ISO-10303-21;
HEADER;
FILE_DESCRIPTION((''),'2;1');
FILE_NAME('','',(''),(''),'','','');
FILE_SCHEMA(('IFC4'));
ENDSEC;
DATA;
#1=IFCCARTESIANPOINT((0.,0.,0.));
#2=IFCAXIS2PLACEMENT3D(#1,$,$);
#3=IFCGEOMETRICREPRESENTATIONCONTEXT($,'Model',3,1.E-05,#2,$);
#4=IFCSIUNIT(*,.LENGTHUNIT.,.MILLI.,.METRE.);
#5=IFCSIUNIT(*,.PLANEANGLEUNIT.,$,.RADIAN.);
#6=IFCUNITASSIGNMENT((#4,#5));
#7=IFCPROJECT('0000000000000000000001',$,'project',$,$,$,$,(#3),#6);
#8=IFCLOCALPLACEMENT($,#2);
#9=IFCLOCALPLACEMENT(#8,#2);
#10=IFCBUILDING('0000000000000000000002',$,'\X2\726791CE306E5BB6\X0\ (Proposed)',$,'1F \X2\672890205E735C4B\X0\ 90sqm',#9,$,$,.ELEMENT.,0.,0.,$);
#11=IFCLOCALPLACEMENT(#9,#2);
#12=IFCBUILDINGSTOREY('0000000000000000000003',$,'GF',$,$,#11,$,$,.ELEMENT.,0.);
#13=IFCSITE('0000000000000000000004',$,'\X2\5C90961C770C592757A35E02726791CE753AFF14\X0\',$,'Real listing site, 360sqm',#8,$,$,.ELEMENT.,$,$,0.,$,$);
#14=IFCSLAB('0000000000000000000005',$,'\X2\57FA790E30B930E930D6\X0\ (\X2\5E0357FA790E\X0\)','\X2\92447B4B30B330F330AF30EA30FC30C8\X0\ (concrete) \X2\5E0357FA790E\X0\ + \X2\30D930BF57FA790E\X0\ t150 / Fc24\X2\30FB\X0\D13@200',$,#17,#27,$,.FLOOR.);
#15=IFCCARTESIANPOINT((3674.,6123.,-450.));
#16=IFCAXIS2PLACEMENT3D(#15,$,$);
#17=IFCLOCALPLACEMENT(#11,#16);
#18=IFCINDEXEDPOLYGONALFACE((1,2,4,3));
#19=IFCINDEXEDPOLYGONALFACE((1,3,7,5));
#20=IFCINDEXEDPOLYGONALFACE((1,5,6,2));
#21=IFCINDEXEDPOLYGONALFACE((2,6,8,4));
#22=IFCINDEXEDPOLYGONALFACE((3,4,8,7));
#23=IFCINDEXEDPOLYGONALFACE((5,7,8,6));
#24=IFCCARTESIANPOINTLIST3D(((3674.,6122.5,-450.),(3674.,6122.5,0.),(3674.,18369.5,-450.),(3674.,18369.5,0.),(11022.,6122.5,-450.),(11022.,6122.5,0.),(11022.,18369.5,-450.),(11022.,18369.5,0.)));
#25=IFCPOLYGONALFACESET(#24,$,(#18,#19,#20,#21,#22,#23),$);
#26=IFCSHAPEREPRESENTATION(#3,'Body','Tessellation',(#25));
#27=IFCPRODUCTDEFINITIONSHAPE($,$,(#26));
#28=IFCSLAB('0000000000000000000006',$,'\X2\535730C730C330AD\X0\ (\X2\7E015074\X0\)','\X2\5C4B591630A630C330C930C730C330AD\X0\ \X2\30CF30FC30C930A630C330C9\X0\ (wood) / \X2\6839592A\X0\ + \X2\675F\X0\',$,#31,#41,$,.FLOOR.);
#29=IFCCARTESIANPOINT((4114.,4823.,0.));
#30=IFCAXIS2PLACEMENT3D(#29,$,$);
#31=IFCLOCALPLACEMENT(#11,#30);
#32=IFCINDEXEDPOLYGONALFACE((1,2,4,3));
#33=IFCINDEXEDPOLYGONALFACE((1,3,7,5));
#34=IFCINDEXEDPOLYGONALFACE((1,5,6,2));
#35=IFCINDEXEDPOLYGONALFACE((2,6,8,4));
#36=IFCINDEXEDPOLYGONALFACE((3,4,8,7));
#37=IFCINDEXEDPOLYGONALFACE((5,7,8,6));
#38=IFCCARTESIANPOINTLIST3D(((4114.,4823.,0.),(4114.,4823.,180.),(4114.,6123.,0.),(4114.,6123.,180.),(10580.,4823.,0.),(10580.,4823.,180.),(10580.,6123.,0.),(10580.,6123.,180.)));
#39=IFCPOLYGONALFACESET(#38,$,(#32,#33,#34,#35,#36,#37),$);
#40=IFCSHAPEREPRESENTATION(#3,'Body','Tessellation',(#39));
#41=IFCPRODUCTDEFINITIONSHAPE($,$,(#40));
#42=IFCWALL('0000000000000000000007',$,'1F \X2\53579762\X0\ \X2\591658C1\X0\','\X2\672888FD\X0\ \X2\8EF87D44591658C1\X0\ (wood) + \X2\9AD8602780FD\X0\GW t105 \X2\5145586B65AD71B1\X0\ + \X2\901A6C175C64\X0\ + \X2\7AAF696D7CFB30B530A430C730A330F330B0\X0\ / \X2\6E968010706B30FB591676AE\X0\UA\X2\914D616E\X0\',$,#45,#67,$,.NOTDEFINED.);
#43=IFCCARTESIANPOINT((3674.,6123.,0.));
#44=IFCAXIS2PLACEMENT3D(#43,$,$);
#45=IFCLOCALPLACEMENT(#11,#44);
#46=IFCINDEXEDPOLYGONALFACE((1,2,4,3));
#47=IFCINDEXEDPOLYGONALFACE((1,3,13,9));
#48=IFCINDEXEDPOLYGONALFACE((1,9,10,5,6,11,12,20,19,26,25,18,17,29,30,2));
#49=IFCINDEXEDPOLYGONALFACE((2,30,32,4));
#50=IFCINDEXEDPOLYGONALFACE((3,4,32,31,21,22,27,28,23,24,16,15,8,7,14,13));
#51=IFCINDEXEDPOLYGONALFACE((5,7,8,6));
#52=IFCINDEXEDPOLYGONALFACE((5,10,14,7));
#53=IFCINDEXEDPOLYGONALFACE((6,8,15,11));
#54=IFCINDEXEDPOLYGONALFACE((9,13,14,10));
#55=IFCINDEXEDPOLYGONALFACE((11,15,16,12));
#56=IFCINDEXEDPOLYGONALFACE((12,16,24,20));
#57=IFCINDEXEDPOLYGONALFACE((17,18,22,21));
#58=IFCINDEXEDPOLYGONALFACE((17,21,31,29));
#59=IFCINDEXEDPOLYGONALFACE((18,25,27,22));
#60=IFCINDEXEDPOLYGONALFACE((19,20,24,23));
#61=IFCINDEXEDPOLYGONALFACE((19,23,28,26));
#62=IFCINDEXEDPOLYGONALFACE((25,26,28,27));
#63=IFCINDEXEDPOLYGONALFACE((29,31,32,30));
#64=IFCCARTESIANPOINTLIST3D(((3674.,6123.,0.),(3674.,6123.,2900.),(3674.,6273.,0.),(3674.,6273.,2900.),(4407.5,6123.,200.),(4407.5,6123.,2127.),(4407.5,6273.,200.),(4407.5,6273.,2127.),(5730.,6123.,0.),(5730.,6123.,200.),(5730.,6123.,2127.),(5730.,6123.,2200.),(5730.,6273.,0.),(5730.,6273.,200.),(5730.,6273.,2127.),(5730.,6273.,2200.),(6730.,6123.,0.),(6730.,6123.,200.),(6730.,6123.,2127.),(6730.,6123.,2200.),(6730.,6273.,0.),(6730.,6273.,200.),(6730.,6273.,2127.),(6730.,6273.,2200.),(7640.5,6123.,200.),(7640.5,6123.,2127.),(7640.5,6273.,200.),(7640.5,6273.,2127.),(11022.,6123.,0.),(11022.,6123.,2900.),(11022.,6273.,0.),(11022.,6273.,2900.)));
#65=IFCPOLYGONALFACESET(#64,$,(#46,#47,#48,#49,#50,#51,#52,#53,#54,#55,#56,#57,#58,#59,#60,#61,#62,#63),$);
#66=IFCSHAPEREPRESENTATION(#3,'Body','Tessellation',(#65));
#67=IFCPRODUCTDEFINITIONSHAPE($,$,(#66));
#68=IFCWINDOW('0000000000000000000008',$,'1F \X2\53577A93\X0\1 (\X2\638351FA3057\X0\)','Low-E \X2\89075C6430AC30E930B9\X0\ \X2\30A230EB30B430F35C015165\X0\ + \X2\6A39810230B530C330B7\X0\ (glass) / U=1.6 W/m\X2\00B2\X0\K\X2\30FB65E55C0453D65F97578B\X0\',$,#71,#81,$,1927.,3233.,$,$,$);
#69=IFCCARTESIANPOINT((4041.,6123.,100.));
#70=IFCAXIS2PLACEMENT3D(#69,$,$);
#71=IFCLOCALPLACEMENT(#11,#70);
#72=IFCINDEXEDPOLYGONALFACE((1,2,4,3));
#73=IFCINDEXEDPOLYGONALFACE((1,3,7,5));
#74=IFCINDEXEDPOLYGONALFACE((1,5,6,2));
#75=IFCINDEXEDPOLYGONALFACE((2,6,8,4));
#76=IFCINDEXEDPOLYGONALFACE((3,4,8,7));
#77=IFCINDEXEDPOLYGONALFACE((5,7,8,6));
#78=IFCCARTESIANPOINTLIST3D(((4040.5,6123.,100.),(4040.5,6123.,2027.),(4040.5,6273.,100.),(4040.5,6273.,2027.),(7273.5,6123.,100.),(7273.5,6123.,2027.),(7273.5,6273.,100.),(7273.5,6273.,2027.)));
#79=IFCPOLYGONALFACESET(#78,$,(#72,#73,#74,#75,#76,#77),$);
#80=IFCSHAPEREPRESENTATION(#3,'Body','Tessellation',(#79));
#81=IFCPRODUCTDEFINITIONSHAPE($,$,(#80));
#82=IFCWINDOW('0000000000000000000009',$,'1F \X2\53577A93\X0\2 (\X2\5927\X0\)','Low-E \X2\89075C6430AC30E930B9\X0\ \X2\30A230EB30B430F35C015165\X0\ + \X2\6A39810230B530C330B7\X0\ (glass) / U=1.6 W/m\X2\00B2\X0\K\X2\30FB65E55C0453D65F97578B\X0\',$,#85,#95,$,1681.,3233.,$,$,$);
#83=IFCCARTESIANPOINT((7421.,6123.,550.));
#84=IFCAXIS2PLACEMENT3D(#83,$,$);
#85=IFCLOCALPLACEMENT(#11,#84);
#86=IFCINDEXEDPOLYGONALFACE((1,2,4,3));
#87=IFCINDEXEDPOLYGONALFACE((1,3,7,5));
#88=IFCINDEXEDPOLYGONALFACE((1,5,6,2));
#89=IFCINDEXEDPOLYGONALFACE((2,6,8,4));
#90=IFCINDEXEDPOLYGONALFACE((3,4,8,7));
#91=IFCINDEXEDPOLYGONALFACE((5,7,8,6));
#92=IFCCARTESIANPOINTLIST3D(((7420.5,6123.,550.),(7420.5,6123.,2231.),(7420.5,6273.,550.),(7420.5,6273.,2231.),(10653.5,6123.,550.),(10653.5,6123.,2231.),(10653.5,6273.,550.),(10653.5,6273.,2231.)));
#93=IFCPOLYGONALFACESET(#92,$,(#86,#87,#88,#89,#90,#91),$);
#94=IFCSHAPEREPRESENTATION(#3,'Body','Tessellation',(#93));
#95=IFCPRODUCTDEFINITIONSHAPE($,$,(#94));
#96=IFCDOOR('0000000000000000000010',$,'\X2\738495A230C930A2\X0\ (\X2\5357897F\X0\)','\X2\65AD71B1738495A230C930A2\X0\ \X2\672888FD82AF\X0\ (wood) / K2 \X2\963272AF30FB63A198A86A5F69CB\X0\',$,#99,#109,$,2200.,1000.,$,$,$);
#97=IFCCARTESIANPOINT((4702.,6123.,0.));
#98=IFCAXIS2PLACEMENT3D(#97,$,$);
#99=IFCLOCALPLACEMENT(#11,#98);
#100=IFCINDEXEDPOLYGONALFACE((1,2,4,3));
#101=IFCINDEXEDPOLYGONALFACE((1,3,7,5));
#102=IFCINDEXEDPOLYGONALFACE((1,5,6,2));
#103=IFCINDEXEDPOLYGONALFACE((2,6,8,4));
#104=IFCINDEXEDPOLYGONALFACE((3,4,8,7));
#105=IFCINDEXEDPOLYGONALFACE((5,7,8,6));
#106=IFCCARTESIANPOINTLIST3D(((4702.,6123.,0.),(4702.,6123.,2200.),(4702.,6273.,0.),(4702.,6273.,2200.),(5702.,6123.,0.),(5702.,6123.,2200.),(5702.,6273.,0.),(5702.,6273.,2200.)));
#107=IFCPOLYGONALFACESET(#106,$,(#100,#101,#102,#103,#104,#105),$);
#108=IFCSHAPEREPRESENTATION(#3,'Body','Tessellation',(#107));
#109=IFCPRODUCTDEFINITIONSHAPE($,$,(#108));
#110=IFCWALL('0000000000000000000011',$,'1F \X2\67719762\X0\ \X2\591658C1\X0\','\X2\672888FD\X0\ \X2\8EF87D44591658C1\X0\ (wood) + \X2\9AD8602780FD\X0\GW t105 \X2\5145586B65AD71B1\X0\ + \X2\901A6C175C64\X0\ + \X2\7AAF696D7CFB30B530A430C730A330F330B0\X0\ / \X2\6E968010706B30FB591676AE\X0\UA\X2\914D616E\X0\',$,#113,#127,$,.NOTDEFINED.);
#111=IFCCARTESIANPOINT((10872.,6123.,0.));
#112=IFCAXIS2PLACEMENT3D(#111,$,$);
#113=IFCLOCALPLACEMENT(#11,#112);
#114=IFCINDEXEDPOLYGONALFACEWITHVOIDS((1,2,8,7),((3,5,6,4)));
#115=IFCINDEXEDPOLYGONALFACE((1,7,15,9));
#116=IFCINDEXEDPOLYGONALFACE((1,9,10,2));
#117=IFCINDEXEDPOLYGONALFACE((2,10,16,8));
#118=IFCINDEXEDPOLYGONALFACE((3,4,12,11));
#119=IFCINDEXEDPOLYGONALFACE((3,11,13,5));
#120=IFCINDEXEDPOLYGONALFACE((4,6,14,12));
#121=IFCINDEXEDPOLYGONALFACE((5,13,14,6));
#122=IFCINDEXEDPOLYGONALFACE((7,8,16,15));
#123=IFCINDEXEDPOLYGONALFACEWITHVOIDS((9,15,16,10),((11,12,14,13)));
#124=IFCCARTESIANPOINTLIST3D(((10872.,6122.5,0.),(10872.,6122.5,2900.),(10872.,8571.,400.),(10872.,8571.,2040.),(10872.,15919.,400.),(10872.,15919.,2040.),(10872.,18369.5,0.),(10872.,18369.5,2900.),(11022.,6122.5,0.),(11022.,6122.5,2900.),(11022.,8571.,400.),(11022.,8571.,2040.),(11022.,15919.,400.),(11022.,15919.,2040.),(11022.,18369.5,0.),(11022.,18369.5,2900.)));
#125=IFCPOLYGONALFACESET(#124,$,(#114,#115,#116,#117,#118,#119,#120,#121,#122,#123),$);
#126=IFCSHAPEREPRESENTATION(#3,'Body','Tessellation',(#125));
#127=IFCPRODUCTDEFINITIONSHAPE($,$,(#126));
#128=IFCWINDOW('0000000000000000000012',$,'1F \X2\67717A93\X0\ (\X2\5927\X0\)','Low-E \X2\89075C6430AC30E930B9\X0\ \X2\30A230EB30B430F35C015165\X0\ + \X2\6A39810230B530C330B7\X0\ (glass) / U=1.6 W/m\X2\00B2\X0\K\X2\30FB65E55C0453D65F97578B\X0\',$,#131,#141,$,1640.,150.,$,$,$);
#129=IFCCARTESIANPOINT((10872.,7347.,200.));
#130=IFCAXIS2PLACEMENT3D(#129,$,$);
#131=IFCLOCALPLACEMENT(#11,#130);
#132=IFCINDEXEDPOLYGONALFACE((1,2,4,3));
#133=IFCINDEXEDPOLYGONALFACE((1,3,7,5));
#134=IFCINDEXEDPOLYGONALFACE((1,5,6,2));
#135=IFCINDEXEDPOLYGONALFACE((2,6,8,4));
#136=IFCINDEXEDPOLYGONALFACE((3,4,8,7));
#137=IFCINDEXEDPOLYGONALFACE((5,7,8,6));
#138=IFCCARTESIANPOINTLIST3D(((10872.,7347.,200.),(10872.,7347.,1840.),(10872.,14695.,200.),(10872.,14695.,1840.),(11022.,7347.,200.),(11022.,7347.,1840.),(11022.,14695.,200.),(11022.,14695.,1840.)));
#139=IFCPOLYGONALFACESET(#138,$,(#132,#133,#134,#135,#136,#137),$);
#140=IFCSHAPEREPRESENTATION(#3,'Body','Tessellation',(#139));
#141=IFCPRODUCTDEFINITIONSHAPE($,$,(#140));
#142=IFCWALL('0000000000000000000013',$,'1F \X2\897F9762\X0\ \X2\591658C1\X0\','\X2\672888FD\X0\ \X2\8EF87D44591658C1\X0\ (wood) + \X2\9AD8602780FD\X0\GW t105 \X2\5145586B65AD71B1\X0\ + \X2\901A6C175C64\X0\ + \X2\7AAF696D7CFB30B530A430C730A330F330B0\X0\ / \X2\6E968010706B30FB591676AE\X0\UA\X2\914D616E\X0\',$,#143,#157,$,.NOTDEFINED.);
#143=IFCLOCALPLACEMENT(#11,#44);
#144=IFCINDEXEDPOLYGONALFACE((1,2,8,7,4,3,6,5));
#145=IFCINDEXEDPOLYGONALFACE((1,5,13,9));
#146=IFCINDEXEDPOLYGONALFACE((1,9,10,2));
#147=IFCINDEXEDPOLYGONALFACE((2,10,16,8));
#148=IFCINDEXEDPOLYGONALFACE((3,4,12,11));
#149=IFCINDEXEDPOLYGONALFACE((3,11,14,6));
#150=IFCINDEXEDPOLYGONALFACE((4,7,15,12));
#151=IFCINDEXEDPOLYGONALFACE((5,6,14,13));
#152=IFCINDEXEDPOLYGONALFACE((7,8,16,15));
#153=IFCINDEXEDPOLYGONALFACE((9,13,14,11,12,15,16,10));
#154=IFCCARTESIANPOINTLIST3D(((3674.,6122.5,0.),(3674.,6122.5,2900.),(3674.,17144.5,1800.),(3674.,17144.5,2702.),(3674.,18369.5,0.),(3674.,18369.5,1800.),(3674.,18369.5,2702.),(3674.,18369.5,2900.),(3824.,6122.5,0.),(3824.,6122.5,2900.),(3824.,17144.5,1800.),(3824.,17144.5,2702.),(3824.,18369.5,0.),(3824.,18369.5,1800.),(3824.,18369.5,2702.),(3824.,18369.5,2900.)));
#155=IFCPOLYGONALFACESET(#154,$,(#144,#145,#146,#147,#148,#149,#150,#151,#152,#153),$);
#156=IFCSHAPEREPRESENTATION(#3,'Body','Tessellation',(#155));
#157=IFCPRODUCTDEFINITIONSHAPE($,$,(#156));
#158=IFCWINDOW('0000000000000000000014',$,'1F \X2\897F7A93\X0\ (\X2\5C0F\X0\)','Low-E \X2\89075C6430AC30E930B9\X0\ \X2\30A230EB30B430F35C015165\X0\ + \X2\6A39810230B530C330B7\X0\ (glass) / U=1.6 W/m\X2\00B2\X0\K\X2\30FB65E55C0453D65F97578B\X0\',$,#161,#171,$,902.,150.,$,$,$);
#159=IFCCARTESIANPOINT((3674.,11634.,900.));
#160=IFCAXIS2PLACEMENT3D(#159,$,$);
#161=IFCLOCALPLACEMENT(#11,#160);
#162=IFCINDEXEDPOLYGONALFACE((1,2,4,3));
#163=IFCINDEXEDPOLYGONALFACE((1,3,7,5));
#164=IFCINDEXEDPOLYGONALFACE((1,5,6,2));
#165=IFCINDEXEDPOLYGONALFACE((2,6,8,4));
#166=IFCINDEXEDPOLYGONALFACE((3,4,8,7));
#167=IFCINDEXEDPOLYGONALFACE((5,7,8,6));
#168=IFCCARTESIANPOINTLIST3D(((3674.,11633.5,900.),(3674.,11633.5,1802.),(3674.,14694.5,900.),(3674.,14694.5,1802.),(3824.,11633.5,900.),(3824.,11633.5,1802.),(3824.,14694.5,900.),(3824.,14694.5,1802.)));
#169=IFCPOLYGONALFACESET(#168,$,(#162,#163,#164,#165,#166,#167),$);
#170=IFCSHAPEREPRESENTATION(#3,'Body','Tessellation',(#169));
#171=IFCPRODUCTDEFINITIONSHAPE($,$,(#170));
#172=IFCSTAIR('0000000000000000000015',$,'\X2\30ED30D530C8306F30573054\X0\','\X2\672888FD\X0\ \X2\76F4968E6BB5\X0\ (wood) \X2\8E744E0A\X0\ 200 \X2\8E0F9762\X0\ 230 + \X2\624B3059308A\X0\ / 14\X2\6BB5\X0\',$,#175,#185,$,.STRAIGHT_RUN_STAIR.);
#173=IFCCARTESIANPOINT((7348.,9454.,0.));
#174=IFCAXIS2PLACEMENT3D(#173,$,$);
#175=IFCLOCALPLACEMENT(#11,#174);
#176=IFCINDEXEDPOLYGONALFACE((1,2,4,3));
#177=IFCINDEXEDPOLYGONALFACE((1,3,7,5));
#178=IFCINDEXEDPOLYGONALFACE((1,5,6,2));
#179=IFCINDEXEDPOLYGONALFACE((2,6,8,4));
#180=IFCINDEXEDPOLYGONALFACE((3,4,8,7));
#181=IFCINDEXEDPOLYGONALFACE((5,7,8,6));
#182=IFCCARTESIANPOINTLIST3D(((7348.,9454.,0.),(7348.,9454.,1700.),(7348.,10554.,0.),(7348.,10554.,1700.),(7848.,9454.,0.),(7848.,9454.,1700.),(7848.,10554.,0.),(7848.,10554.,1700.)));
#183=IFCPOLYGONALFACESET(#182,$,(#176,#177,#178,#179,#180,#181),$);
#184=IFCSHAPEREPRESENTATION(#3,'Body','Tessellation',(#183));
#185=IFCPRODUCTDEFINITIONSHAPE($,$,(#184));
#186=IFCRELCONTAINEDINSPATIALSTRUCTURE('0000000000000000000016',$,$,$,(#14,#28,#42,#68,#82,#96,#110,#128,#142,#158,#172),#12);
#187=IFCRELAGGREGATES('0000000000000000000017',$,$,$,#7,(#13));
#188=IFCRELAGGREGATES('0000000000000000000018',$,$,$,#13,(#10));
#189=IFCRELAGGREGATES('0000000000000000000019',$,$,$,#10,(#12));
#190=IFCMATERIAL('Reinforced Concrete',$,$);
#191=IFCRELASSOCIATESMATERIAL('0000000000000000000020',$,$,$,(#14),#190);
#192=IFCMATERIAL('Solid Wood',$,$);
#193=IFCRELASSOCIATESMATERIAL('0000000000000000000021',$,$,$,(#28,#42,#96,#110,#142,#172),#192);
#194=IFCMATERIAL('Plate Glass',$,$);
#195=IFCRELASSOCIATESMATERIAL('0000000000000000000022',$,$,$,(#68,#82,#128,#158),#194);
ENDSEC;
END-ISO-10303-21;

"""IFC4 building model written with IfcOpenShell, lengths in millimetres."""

from ifc_helpers import new_model, si_unit, frame, frame_2d, origin, place, context, project, spatial, rectangle, extrude, material, element, fill, save


model = new_model("IFC4")

# Units and contexts
model_context = context("Model", 3, precision=1e-05, world=origin())
ifc_project = project(units=[si_unit("LENGTHUNIT", "METRE", prefix="MILLI"), si_unit("PLANEANGLEUNIT", "RADIAN")], contexts=[model_context])

# Site, building, storey
site_placement = place(None, origin())
site = spatial("IfcSite", under=ifc_project, at=site_placement, Name="岐阜県大垣市牧野町４", ObjectType="Real listing site, 360sqm", CompositionType="ELEMENT", RefElevation=0.0)
building_placement = place(site_placement, origin())
building = spatial("IfcBuilding", under=site, at=building_placement, Name="牧野の家 (Proposed)", ObjectType="1F 木造平屋 90sqm", CompositionType="ELEMENT", ElevationOfRefHeight=0.0, ElevationOfTerrain=0.0)
storey_placement = place(building_placement, origin())
storey = spatial("IfcBuildingStorey", under=building, at=storey_placement, Name="GF", CompositionType="ELEMENT", Elevation=0.0)

# Slabs
ifc_material_1 = material(Name="Reinforced Concrete")
slab_1_placement = place(storey_placement, frame((3674.0, 6123.0, -450.0)))
element("IfcSlab", 1, at=slab_1_placement, inside=storey, material=ifc_material_1, Name="基礎スラブ (布基礎)", Description="鉄筋コンクリート (concrete) 布基礎 + ベタ基礎 t150 / Fc24・D13@200", PredefinedType="FLOOR", context=model_context, shape_type="SweptSolid", body=[
    extrude(rectangle(XDim=7348.0, YDim=12247.0, at=frame_2d((3674.0, 6123.0))), frame((3674.0, 6123.0, -450.0)), (0.0, 0.0, 1.0), 450.0),
])
ifc_material_2 = material(Name="Solid Wood")
slab_2_placement = place(storey_placement, frame((4114.0, 4823.0, 0.0)))
element("IfcSlab", 2, at=slab_2_placement, inside=storey, material=ifc_material_2, Name="南デッキ (縁側)", Description="屋外ウッドデッキ ハードウッド (wood) / 根太 + 束", PredefinedType="FLOOR", context=model_context, shape_type="SweptSolid", body=[
    extrude(rectangle(XDim=6466.0, YDim=1300.0, at=frame_2d((3233.0, 650.0))), frame((4114.0, 4823.0, 0.0)), (0.0, 0.0, 1.0), 180.0),
])

# Wall, openings, windows, door
wall_1_placement = place(storey_placement, frame((3674.0, 6123.0, 0.0)))
wall_1 = element("IfcWall", 3, at=wall_1_placement, inside=storey, material=ifc_material_2, Name="1F 南面 外壁", Description="木製 軸組外壁 (wood) + 高性能GW t105 充填断熱 + 通気層 + 窯業系サイディング / 準耐火・外皮UA配慮", PredefinedType="NOTDEFINED", context=model_context, shape_type="SweptSolid", body=[
    extrude(rectangle(XDim=7348.0, YDim=150.0, at=frame_2d((3674.0, 75.0))), frame((3674.0, 6123.0, 0.0)), (0.0, 0.0, 1.0), 2900.0),
])
opening_1_placement = place(storey_placement, frame((4041.0, 6123.0, 100.0)))
opening_1 = element("IfcOpeningElement", 4, at=opening_1_placement, cuts=wall_1, PredefinedType="NOTDEFINED", context=model_context, shape_type="SweptSolid", body=[
    extrude(rectangle(XDim=3233.0, YDim=150.0, at=frame_2d((1616.0, 75.0))), frame((4041.0, 6123.0, 100.0)), (0.0, 0.0, 1.0), 1927.0),
])
opening_2_placement = place(storey_placement, frame((7421.0, 6123.0, 550.0)))
opening_2 = element("IfcOpeningElement", 5, at=opening_2_placement, cuts=wall_1, PredefinedType="NOTDEFINED", context=model_context, shape_type="SweptSolid", body=[
    extrude(rectangle(XDim=3233.0, YDim=150.0, at=frame_2d((1616.0, 75.0))), frame((7421.0, 6123.0, 550.0)), (0.0, 0.0, 1.0), 1681.0),
])
opening_3_placement = place(storey_placement, frame((4702.0, 6123.0, 0.0)))
opening_3 = element("IfcOpeningElement", 6, at=opening_3_placement, cuts=wall_1, PredefinedType="NOTDEFINED", context=model_context, shape_type="SweptSolid", body=[
    extrude(rectangle(XDim=1000.0, YDim=150.0, at=frame_2d((500.0, 75.0))), frame((4702.0, 6123.0, 0.0)), (0.0, 0.0, 1.0), 2200.0),
])
ifc_material_3 = material(Name="Plate Glass")
window_1_placement = place(storey_placement, frame((4041.0, 6123.0, 100.0)))
window_1 = element("IfcWindow", 7, at=window_1_placement, inside=storey, material=ifc_material_3, Name="1F 南窓1 (掃出し)", Description="Low-E 複層ガラス アルゴン封入 + 樹脂サッシ (glass) / U=1.6 W/m²K・日射取得型", OverallHeight=1927.0, OverallWidth=3233.0, context=model_context, shape_type="SweptSolid", body=[
    extrude(rectangle(XDim=3233.0, YDim=150.0, at=frame_2d((1616.0, 75.0))), frame((4041.0, 6123.0, 100.0)), (0.0, 0.0, 1.0), 1927.0),
])
fill(opening_1, window_1)
window_2_placement = place(storey_placement, frame((7421.0, 6123.0, 550.0)))
window_2 = element("IfcWindow", 8, at=window_2_placement, inside=storey, material=ifc_material_3, Name="1F 南窓2 (大)", Description="Low-E 複層ガラス アルゴン封入 + 樹脂サッシ (glass) / U=1.6 W/m²K・日射取得型", OverallHeight=1681.0, OverallWidth=3233.0, context=model_context, shape_type="SweptSolid", body=[
    extrude(rectangle(XDim=3233.0, YDim=150.0, at=frame_2d((1616.0, 75.0))), frame((7421.0, 6123.0, 550.0)), (0.0, 0.0, 1.0), 1681.0),
])
fill(opening_2, window_2)
door_placement = place(storey_placement, frame((4702.0, 6123.0, 0.0)))
door = element("IfcDoor", 9, at=door_placement, inside=storey, material=ifc_material_2, Name="玄関ドア (南西)", Description="断熱玄関ドア 木製芯 (wood) / K2 防犯・採風機構", OverallHeight=2200.0, OverallWidth=1000.0, context=model_context, shape_type="SweptSolid", body=[
    extrude(rectangle(XDim=1000.0, YDim=150.0, at=frame_2d((500.0, 75.0))), frame((4702.0, 6123.0, 0.0)), (0.0, 0.0, 1.0), 2200.0),
])
fill(opening_3, door)

# Walls, openings, windows
wall_2_placement = place(storey_placement, frame((10872.0, 6123.0, 0.0)))
wall_2 = element("IfcWall", 10, at=wall_2_placement, inside=storey, material=ifc_material_2, Name="1F 東面 外壁", Description="木製 軸組外壁 (wood) + 高性能GW t105 充填断熱 + 通気層 + 窯業系サイディング / 準耐火・外皮UA配慮", PredefinedType="NOTDEFINED", context=model_context, shape_type="SweptSolid", body=[
    extrude(rectangle(XDim=150.0, YDim=12247.0, at=frame_2d((75.0, 6123.0))), frame((10872.0, 6123.0, 0.0)), (0.0, 0.0, 1.0), 2900.0),
])
opening_4_placement = place(storey_placement, frame((10872.0, 7347.0, 200.0)))
opening_4 = element("IfcOpeningElement", 11, at=opening_4_placement, cuts=wall_2, PredefinedType="NOTDEFINED", context=model_context, shape_type="SweptSolid", body=[
    extrude(rectangle(XDim=150.0, YDim=7348.0, at=frame_2d((75.0, 3674.0))), frame((10872.0, 7347.0, 200.0)), (0.0, 0.0, 1.0), 1640.0),
])
window_3_placement = place(storey_placement, frame((10872.0, 7347.0, 200.0)))
window_3 = element("IfcWindow", 12, at=window_3_placement, inside=storey, material=ifc_material_3, Name="1F 東窓 (大)", Description="Low-E 複層ガラス アルゴン封入 + 樹脂サッシ (glass) / U=1.6 W/m²K・日射取得型", OverallHeight=1640.0, OverallWidth=150.0, context=model_context, shape_type="SweptSolid", body=[
    extrude(rectangle(XDim=150.0, YDim=7348.0, at=frame_2d((75.0, 3674.0))), frame((10872.0, 7347.0, 200.0)), (0.0, 0.0, 1.0), 1640.0),
])
fill(opening_4, window_3)
wall_3_placement = place(storey_placement, frame((3674.0, 6123.0, 0.0)))
wall_3 = element("IfcWall", 13, at=wall_3_placement, inside=storey, material=ifc_material_2, Name="1F 西面 外壁", Description="木製 軸組外壁 (wood) + 高性能GW t105 充填断熱 + 通気層 + 窯業系サイディング / 準耐火・外皮UA配慮", PredefinedType="NOTDEFINED", context=model_context, shape_type="SweptSolid", body=[
    extrude(rectangle(XDim=150.0, YDim=12247.0, at=frame_2d((75.0, 6123.0))), frame((3674.0, 6123.0, 0.0)), (0.0, 0.0, 1.0), 2900.0),
])
opening_5_placement = place(storey_placement, frame((3674.0, 11634.0, 900.0)))
opening_5 = element("IfcOpeningElement", 14, at=opening_5_placement, cuts=wall_3, PredefinedType="NOTDEFINED", context=model_context, shape_type="SweptSolid", body=[
    extrude(rectangle(XDim=150.0, YDim=3061.0, at=frame_2d((75.0, 1530.0))), frame((3674.0, 11634.0, 900.0)), (0.0, 0.0, 1.0), 902.0),
])
window_4_placement = place(storey_placement, frame((3674.0, 11634.0, 900.0)))
window_4 = element("IfcWindow", 15, at=window_4_placement, inside=storey, material=ifc_material_3, Name="1F 西窓 (小)", Description="Low-E 複層ガラス アルゴン封入 + 樹脂サッシ (glass) / U=1.6 W/m²K・日射取得型", OverallHeight=902.0, OverallWidth=150.0, context=model_context, shape_type="SweptSolid", body=[
    extrude(rectangle(XDim=150.0, YDim=3061.0, at=frame_2d((75.0, 1530.0))), frame((3674.0, 11634.0, 900.0)), (0.0, 0.0, 1.0), 902.0),
])
fill(opening_5, window_4)

# Stair
stair_placement = place(storey_placement, frame((7348.0, 9454.0, 0.0)))
element("IfcStair", 16, at=stair_placement, inside=storey, material=ifc_material_2, Name="ロフトはしご", Description="木製 直階段 (wood) 蹴上 200 踏面 230 + 手すり / 14段", PredefinedType="STRAIGHT_RUN_STAIR", context=model_context, shape_type="SweptSolid", body=[
    extrude(rectangle(XDim=500.0, YDim=1100.0, at=frame_2d((250.0, 550.0))), frame((7348.0, 9454.0, 0.0)), (0.0, 0.0, 1.0), 1700.0),
])

save(model, "model.ifc")
